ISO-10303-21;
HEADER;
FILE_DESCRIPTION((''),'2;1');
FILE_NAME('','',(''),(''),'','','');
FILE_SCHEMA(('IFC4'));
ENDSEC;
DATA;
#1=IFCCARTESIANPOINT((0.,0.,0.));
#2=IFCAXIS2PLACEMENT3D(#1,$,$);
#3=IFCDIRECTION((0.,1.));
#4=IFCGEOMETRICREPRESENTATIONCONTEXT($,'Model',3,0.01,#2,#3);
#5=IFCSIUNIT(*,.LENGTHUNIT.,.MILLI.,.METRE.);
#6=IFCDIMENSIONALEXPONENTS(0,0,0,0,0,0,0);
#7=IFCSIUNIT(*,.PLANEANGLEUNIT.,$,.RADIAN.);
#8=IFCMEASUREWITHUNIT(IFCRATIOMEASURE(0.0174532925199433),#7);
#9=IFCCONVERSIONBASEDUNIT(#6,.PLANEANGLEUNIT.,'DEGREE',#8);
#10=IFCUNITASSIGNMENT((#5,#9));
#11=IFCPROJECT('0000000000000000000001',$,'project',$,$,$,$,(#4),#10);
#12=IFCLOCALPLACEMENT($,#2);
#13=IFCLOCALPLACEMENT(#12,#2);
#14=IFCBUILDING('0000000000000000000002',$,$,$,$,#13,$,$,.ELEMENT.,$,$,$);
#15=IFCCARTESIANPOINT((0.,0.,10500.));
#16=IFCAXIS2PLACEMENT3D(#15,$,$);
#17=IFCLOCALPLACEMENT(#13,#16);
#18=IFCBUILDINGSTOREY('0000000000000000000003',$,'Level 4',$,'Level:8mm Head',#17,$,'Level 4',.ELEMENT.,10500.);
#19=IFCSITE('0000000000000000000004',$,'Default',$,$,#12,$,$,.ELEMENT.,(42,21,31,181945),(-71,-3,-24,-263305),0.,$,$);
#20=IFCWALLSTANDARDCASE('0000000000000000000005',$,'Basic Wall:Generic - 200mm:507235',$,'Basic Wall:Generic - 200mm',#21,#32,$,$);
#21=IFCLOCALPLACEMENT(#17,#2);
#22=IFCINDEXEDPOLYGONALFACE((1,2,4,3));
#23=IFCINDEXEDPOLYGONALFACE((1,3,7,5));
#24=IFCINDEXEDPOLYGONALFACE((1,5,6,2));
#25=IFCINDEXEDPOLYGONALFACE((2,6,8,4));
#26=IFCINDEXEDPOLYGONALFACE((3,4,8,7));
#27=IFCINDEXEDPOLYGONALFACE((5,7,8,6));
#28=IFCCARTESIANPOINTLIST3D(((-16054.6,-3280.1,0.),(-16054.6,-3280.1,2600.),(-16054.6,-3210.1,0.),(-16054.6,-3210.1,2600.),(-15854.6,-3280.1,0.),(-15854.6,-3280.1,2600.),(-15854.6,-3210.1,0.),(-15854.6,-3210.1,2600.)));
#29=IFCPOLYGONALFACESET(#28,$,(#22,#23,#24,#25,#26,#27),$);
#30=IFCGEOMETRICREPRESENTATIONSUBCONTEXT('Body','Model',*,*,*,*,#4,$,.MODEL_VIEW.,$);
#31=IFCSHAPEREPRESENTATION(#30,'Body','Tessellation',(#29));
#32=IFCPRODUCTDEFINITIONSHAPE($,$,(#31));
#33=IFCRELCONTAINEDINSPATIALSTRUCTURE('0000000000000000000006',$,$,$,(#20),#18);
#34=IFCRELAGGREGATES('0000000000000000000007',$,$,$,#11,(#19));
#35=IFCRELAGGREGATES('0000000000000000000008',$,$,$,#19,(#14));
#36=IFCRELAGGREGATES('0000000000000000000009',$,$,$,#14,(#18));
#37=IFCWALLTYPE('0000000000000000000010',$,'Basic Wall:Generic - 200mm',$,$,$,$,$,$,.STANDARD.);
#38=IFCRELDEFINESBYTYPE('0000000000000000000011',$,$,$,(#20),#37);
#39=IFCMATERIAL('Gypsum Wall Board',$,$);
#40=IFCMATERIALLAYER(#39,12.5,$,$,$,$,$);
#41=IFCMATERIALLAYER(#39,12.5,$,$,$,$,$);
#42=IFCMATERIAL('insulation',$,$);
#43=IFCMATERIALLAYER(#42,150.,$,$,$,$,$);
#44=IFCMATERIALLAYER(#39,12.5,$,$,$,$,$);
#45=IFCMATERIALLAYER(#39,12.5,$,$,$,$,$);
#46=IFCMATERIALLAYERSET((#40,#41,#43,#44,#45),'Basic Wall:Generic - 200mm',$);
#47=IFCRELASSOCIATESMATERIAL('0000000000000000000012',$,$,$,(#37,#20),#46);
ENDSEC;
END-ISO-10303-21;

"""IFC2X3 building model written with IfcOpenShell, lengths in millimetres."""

from ifc_helpers import new_model, entity, si_unit, converted_unit, direction, frame, frame_2d, origin, place, context, subcontext, project, spatial, rectangle, extrude, material, layer, layer_set, layer_usage, type_object, element, save


model = new_model("IFC2X3")

# Units and contexts
model_context = context("Model", 3, precision=0.01, world=origin(), true_north=direction((0.0, 1.0)))
body_context = subcontext(model_context, "Body", "Model", "MODEL_VIEW")
ifc_project = project(units=[si_unit("LENGTHUNIT", "METRE", prefix="MILLI"), converted_unit("PLANEANGLEUNIT", "DEGREE", entity("IfcRatioMeasure", 0.0174532925199433), si_unit("PLANEANGLEUNIT", "RADIAN"), dimensions=[0, 0, 0, 0, 0, 0, 0])], contexts=[model_context])

# Site, building, storey
site_placement = place(None, frame((0.0, 0.0, 0.0)))
site = spatial("IfcSite", under=ifc_project, at=site_placement, Name="Default", CompositionType="ELEMENT", RefLatitude=(42, 21, 31, 181945), RefLongitude=(-71, -3, -24, -263305), RefElevation=0.0)
building_placement = place(site_placement, origin())
building = spatial("IfcBuilding", under=site, at=building_placement, CompositionType="ELEMENT")
storey_placement = place(building_placement, frame((0.0, 0.0, 10500.0)))
storey = spatial("IfcBuildingStorey", under=building, at=storey_placement, Name="Level 4", ObjectType="Level:8mm Head", LongName="Level 4", CompositionType="ELEMENT", Elevation=10500.0)

# Shared definitions
ifc_material_1 = material(Name="Gypsum Wall Board")
ifc_layer_1 = layer(ifc_material_1, 12.5)
ifc_layer_2 = layer(ifc_material_1, 12.5)
ifc_material_2 = material(Name="insulation")
ifc_layer_3 = layer(ifc_material_2, 150.0)
ifc_layer_4 = layer(ifc_material_1, 12.5)
ifc_layer_5 = layer(ifc_material_1, 12.5)
ifc_layer_set = layer_set([ifc_layer_1, ifc_layer_2, ifc_layer_3, ifc_layer_4, ifc_layer_5], Name="Basic Wall:Generic - 200mm")
wall_type = type_object("IfcWallType", Name="Basic Wall:Generic - 200mm", PredefinedType="STANDARD", material=ifc_layer_set)

# Wall
ifc_layer_usage_1 = layer_usage(ifc_layer_set, "AXIS2", "NEGATIVE", 100.0)
wall_1_placement = place(storey_placement, frame((-15954.6, -3280.1, 0.0), z_axis=(0.0, 0.0, 1.0), x_axis=(0.0, 1.0, 0.0)))
element("IfcWallStandardCase", 1, at=wall_1_placement, inside=storey, type_object=wall_type, material=ifc_layer_usage_1, Name="Basic Wall:Generic - 200mm:507235", ObjectType="Basic Wall:Generic - 200mm", context=body_context, shape_type="SweptSolid", body=[
    extrude(rectangle(XDim=70.0, YDim=200.0, at=frame_2d((35.0, 0.0), x_axis=(-1.0, 0.0))), origin(), (0.0, 0.0, 1.0), 2600.0),
])

save(model, "model.ifc")
